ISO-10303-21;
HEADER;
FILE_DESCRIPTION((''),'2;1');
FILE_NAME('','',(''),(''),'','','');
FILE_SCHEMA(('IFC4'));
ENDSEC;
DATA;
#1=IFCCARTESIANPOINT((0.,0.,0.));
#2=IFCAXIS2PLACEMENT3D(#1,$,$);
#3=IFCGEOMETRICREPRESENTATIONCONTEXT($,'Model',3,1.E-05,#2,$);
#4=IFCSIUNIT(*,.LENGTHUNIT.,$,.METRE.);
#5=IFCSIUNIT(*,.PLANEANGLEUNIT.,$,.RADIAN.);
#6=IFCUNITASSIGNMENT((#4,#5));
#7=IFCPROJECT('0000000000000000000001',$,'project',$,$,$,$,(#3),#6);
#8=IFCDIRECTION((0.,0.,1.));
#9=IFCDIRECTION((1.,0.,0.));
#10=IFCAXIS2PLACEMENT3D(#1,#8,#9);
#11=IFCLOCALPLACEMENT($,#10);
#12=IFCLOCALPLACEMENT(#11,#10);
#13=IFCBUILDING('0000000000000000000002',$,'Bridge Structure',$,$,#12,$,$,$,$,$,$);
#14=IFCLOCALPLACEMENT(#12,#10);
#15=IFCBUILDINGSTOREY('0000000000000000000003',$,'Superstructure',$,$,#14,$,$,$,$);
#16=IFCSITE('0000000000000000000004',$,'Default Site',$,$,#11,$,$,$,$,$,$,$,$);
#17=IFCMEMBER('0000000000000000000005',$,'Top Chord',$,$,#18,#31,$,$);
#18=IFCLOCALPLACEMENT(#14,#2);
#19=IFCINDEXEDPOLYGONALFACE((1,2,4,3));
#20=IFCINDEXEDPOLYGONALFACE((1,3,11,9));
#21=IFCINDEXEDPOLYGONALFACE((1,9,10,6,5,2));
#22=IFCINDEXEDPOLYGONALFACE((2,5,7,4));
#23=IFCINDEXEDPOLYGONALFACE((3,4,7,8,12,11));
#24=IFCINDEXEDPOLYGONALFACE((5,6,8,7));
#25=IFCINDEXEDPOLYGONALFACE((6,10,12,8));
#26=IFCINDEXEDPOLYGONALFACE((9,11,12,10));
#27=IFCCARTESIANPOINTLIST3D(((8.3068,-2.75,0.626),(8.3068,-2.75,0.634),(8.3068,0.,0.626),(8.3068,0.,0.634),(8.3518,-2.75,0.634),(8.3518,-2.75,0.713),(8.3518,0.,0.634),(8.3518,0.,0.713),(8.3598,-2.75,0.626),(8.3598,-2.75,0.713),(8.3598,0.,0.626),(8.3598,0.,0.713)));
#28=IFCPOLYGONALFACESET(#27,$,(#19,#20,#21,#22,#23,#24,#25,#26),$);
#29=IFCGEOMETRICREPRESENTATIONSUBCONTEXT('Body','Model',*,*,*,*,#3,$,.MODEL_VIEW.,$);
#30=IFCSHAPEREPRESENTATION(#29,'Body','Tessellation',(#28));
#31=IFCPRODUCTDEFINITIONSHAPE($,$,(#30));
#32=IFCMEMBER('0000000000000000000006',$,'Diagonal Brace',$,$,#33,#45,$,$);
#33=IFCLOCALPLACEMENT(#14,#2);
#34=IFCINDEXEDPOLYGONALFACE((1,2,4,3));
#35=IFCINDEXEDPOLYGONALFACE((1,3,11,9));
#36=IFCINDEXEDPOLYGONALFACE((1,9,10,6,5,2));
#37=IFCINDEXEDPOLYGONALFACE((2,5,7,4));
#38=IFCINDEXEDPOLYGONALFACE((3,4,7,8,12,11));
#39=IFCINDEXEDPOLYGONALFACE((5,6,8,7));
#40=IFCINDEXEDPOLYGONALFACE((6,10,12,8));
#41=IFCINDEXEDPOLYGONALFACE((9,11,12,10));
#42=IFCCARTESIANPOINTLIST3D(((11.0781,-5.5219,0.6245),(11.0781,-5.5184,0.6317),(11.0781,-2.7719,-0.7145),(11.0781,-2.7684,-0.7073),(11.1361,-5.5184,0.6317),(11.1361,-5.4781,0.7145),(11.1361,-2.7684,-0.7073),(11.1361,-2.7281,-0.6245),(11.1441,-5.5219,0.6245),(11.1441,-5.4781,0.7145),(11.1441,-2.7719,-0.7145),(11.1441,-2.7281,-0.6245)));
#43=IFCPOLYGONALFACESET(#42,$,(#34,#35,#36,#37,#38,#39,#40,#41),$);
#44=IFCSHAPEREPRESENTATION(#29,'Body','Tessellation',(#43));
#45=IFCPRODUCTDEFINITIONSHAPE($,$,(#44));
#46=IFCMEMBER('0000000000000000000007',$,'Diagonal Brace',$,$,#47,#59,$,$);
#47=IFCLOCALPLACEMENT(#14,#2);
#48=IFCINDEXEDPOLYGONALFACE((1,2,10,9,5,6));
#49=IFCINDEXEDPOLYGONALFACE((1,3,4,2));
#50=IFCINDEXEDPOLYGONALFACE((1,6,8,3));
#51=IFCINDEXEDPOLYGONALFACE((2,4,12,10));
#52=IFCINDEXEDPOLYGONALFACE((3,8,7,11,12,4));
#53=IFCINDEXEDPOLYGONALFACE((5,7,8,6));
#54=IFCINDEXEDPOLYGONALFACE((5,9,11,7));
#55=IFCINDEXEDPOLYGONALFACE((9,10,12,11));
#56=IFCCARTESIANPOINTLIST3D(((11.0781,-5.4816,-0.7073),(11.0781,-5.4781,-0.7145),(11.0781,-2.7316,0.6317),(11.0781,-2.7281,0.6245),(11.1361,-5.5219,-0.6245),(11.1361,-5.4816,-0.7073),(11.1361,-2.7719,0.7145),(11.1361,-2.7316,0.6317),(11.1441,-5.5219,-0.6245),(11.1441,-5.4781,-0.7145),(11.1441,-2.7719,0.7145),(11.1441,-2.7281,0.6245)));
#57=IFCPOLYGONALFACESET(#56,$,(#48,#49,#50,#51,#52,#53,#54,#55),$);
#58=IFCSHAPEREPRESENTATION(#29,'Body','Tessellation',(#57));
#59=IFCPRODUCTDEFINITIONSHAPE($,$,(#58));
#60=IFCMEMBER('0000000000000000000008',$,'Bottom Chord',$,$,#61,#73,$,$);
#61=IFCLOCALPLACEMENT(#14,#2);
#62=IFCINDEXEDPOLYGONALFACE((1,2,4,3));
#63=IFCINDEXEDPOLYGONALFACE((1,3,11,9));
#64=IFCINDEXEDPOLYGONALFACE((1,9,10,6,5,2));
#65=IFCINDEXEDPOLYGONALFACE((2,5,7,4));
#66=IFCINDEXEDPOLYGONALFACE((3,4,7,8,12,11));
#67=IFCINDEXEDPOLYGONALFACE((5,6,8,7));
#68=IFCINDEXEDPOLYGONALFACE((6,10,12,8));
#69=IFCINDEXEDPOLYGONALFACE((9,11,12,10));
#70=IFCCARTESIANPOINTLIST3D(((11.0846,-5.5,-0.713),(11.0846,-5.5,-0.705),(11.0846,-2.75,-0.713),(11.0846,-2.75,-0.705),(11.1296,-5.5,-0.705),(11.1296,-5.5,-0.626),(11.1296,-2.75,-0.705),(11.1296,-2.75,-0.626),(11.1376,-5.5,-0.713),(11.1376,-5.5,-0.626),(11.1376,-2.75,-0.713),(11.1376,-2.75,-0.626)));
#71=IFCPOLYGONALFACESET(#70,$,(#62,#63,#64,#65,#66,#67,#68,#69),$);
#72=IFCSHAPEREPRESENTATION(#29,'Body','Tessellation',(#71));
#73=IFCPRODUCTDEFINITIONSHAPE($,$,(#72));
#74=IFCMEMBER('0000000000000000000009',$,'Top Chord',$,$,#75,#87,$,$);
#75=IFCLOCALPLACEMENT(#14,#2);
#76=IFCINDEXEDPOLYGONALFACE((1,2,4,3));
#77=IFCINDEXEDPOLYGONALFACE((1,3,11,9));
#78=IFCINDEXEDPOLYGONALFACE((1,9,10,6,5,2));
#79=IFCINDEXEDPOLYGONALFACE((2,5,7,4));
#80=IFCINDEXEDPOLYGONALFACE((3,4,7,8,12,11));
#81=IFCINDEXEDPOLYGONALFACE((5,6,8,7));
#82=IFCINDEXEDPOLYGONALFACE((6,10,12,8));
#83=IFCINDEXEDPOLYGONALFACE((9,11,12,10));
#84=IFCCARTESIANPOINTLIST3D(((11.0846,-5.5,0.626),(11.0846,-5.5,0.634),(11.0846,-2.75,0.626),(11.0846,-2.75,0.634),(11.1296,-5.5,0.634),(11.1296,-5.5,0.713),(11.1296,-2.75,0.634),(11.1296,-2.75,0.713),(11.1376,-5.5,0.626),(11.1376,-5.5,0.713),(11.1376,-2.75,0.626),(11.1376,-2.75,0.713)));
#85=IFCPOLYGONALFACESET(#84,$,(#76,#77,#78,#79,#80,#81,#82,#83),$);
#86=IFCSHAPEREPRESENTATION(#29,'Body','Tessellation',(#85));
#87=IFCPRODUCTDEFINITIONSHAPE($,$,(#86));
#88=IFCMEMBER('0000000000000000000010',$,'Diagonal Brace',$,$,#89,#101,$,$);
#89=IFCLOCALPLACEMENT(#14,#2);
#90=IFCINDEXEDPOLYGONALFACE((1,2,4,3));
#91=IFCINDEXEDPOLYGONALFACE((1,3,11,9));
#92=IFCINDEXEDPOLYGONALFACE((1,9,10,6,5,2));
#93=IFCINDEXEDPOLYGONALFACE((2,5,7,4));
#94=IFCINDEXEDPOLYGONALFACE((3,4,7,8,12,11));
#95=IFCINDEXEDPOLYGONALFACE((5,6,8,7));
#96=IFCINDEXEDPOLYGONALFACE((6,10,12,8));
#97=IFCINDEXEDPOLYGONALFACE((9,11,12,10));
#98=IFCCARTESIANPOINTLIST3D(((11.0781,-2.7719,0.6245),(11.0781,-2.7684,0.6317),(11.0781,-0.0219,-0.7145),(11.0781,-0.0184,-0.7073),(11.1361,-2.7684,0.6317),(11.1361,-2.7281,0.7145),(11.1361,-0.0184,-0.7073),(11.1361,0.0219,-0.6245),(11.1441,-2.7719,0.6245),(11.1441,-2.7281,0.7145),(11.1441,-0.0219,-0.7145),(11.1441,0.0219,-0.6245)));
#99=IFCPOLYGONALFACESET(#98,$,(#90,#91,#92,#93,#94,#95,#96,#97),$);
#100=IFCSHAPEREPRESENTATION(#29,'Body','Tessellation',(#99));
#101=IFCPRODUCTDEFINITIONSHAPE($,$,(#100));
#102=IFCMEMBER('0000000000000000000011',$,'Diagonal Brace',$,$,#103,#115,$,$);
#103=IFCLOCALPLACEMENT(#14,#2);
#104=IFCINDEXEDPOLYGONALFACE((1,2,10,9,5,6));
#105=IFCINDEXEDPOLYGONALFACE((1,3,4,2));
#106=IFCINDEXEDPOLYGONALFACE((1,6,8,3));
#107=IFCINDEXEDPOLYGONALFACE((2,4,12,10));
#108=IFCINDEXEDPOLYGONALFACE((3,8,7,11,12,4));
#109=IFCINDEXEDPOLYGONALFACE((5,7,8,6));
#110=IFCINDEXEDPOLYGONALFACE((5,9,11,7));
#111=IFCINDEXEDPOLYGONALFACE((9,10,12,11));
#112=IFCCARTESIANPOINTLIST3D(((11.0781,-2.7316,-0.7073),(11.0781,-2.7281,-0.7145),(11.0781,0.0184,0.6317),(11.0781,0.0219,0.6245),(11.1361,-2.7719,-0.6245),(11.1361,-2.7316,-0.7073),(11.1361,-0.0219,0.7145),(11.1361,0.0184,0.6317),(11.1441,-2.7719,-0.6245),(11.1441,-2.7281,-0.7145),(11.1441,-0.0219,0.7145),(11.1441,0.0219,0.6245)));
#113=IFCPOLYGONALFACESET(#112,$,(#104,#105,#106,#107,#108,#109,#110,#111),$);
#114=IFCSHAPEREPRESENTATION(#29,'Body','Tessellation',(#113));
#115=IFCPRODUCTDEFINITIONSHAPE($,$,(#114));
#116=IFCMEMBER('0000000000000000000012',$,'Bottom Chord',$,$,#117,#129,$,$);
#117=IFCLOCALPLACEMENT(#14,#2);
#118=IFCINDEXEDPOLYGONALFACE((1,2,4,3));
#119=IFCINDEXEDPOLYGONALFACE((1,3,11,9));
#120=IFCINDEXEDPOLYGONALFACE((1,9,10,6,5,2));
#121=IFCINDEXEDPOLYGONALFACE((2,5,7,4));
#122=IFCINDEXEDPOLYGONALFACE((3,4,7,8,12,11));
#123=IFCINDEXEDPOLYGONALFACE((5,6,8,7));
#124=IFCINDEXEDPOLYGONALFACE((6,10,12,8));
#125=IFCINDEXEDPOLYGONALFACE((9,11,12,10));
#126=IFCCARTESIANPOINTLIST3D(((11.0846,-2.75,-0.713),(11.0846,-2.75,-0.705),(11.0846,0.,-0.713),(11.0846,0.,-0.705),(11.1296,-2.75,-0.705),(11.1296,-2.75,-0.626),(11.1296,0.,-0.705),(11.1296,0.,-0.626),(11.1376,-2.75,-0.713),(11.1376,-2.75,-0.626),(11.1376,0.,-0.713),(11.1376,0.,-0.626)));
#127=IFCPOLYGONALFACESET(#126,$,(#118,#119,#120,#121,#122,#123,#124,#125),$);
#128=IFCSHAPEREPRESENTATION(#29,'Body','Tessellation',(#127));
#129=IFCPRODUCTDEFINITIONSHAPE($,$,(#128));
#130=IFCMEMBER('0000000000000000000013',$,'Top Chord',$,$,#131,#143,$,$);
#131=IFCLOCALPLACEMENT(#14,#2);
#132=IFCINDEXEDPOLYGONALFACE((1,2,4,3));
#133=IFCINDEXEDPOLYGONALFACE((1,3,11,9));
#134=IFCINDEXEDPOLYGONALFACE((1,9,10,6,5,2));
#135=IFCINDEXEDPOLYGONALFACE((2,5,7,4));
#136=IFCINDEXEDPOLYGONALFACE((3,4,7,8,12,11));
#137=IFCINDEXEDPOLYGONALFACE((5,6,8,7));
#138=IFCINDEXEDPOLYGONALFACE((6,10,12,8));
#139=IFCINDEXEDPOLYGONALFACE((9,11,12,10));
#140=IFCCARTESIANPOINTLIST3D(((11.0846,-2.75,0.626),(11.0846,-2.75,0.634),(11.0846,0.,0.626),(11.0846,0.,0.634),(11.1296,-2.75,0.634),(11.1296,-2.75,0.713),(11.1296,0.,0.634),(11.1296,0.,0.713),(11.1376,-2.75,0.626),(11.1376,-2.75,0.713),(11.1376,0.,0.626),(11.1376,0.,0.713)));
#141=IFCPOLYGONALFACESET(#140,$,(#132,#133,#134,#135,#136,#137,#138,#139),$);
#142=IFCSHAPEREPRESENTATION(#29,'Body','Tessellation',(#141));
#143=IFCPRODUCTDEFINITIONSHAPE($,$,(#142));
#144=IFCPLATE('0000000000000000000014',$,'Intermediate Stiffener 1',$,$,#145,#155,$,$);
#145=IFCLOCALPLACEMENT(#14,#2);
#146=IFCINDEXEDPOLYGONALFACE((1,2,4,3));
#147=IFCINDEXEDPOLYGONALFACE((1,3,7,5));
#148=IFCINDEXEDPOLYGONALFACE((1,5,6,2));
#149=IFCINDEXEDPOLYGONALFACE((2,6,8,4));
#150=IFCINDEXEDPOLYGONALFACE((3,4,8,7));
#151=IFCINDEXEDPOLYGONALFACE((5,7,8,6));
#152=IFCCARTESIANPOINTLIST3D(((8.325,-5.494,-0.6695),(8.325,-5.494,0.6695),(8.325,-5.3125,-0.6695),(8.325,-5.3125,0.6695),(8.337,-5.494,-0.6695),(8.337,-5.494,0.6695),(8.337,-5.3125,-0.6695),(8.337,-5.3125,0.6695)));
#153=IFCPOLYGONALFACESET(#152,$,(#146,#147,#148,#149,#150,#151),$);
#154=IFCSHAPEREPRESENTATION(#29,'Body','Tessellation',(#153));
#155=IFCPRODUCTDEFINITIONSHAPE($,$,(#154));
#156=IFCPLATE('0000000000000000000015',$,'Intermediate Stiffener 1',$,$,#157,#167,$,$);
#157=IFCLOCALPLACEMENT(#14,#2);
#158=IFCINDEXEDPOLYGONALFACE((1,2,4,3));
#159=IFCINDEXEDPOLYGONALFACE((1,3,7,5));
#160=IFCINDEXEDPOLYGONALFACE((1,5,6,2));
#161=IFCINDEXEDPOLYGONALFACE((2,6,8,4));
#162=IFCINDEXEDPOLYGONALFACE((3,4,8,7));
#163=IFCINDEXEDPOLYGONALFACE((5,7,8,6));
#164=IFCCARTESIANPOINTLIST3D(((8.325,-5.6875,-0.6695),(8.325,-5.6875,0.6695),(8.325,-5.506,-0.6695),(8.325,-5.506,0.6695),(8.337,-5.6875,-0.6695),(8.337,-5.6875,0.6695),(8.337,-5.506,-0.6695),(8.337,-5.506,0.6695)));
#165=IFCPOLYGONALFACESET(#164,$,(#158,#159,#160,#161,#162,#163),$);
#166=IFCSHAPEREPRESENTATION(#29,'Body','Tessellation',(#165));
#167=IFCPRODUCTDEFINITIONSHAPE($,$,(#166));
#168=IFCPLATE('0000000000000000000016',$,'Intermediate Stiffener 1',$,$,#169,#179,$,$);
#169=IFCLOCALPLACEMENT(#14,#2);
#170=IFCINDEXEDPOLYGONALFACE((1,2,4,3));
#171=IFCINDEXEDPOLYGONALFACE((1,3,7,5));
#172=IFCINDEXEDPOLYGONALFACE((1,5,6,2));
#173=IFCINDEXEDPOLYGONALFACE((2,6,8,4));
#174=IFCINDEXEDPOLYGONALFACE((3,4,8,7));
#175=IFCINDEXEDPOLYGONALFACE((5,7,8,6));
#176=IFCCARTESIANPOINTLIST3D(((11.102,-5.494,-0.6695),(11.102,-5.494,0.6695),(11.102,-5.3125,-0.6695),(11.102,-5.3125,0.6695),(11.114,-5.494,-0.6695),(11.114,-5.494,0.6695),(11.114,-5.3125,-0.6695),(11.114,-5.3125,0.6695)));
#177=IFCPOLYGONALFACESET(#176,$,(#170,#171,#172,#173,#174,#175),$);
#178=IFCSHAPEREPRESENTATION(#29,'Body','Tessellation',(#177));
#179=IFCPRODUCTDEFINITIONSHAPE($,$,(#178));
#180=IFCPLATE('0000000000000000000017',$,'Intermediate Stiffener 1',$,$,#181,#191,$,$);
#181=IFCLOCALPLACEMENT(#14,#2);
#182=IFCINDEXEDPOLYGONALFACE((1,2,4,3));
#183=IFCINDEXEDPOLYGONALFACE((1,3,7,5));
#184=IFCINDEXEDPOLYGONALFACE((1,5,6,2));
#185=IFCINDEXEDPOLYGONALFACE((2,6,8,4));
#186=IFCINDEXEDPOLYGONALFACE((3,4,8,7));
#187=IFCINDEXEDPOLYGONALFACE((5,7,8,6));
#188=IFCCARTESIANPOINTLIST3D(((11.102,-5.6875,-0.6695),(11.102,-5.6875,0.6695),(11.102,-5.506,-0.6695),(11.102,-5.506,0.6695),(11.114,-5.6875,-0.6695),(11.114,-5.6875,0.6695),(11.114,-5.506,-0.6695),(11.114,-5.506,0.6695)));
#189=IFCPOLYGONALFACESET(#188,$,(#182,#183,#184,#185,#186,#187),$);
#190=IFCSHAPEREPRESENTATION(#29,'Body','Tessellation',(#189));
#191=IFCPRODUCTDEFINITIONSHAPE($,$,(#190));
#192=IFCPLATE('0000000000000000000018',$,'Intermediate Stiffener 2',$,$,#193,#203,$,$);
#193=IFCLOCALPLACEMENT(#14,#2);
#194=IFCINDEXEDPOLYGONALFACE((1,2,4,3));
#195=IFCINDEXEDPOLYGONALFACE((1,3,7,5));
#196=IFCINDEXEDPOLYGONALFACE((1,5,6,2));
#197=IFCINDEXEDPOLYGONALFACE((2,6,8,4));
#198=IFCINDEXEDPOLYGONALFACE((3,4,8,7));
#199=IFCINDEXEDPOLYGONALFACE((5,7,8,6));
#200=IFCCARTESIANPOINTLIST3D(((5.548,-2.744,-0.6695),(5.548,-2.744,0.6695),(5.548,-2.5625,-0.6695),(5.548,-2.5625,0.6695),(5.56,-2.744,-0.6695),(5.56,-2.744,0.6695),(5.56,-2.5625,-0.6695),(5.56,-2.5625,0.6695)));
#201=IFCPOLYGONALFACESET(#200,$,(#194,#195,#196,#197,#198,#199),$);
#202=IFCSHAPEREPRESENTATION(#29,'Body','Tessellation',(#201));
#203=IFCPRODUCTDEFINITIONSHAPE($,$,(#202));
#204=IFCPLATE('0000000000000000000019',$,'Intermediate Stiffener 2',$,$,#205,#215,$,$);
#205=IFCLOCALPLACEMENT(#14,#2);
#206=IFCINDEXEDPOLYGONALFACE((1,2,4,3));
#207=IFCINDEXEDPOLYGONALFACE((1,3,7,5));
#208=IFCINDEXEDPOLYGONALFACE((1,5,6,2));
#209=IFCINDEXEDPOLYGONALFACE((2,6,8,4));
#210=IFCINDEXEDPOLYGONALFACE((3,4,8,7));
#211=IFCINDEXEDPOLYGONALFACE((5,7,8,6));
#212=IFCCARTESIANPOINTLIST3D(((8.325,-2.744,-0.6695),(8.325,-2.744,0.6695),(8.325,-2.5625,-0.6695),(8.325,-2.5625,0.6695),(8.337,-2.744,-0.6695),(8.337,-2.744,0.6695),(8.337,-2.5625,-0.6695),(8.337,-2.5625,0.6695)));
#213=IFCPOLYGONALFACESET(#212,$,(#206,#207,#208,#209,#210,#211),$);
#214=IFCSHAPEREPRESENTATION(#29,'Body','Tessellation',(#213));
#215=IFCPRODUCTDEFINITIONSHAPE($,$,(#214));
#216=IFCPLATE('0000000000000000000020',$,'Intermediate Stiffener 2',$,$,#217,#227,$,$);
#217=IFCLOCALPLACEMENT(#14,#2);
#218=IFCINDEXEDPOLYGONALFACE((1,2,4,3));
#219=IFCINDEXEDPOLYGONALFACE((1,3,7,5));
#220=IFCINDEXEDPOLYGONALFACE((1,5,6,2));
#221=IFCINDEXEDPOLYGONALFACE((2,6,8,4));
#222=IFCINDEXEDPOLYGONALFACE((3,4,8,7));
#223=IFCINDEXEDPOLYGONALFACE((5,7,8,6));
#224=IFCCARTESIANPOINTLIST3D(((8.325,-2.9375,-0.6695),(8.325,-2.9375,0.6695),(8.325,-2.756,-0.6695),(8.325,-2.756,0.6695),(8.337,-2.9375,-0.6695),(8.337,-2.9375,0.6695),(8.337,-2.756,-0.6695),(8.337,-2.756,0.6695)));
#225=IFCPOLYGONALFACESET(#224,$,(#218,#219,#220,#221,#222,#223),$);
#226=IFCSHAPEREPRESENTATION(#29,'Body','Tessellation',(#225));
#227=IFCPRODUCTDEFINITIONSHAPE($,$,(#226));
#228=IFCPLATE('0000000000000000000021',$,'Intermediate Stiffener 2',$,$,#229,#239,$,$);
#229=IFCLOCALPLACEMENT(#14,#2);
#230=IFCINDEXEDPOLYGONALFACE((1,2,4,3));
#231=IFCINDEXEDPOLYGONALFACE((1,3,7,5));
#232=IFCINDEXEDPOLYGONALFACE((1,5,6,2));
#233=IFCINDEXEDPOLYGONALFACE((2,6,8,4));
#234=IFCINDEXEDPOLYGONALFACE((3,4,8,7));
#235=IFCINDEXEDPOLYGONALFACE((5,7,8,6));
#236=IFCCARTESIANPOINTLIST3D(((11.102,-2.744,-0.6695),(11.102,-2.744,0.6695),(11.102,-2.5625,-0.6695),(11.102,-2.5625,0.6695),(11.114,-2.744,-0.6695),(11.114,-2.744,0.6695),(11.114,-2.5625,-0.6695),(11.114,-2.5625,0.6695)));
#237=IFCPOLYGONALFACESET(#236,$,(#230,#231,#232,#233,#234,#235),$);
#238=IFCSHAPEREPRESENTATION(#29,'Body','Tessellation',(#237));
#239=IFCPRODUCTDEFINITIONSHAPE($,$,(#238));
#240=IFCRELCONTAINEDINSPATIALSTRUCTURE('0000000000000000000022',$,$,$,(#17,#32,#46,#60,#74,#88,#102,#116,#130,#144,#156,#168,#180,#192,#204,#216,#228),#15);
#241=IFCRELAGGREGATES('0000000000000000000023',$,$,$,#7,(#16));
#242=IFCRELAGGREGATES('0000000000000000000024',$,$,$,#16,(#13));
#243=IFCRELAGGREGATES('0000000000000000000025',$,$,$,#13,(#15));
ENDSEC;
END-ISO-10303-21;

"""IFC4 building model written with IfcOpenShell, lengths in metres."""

from ifc_helpers import new_model, si_unit, frame, origin, origin_with_axes, origin_2d_with_axis, place, context, subcontext, project, spatial, rectangle, l_section, extrude, element, save


model = new_model("IFC4")

# Units and contexts
model_context = context("Model", 3, precision=1e-05, world=origin())
body_context = subcontext(model_context, "Body", "Model", "MODEL_VIEW")
ifc_project = project(units=[si_unit("LENGTHUNIT", "METRE"), si_unit("PLANEANGLEUNIT", "RADIAN")], contexts=[model_context])

# Site, building, storey
site_placement = place(None, origin_with_axes())
site = spatial("IfcSite", under=ifc_project, at=site_placement, Name="Default Site")
building_placement = place(site_placement, origin_with_axes())
building = spatial("IfcBuilding", under=site, at=building_placement, Name="Bridge Structure")
storey_placement = place(building_placement, origin_with_axes())
storey = spatial("IfcBuildingStorey", under=building, at=storey_placement, Name="Superstructure")

# Members
for number, where, z_axis, x_axis, name in (
    (1, (8.3333, -2.75, 0.6695), (0.0, 1.0, 0.0), (-1.0, 0.0, 0.0), "Top Chord"),
):
    element("IfcMember", number, at=place(storey_placement, frame(where, z_axis=z_axis, x_axis=x_axis)), inside=storey, Name=name, context=body_context, shape_type="SweptSolid", body=[
        extrude(l_section(Depth=0.087, Width=0.053, Thickness=0.008, at=origin_2d_with_axis()), origin_with_axes(), (0.0, 0.0, 1.0), 2.75),
    ])
for number, where, z_axis, x_axis, name in (
    (2, (11.1111, -5.5, 0.6695), (0.0, 0.899086, -0.437773), (-1.0, 0.0, 0.0), "Diagonal Brace"),
    (3, (11.1111, -5.5, -0.6695), (0.0, 0.899086, 0.437773), (-1.0, 0.0, 0.0), "Diagonal Brace"),
):
    element("IfcMember", number, at=place(storey_placement, frame(where, z_axis=z_axis, x_axis=x_axis)), inside=storey, Name=name, context=body_context, shape_type="SweptSolid", body=[
        extrude(l_section(Depth=0.1, Width=0.066, Thickness=0.008, at=origin_2d_with_axis()), origin_with_axes(), (0.0, 0.0, 1.0), 3.0587),
    ])
for number, where, z_axis, x_axis, name in (
    (4, (11.1111, -5.5, -0.6695), (0.0, 1.0, 0.0), (-1.0, 0.0, 0.0), "Bottom Chord"),
    (5, (11.1111, -5.5, 0.6695), (0.0, 1.0, 0.0), (-1.0, 0.0, 0.0), "Top Chord"),
):
    element("IfcMember", number, at=place(storey_placement, frame(where, z_axis=z_axis, x_axis=x_axis)), inside=storey, Name=name, context=body_context, shape_type="SweptSolid", body=[
        extrude(l_section(Depth=0.087, Width=0.053, Thickness=0.008, at=origin_2d_with_axis()), origin_with_axes(), (0.0, 0.0, 1.0), 2.75),
    ])
for number, where, z_axis, x_axis, name in (
    (6, (11.1111, -2.75, 0.6695), (0.0, 0.899086, -0.437773), (-1.0, 0.0, 0.0), "Diagonal Brace"),
    (7, (11.1111, -2.75, -0.6695), (0.0, 0.899086, 0.437773), (-1.0, 0.0, 0.0), "Diagonal Brace"),
):
    element("IfcMember", number, at=place(storey_placement, frame(where, z_axis=z_axis, x_axis=x_axis)), inside=storey, Name=name, context=body_context, shape_type="SweptSolid", body=[
        extrude(l_section(Depth=0.1, Width=0.066, Thickness=0.008, at=origin_2d_with_axis()), origin_with_axes(), (0.0, 0.0, 1.0), 3.0587),
    ])
for number, where, z_axis, x_axis, name in (
    (8, (11.1111, -2.75, -0.6695), (0.0, 1.0, 0.0), (-1.0, 0.0, 0.0), "Bottom Chord"),
    (9, (11.1111, -2.75, 0.6695), (0.0, 1.0, 0.0), (-1.0, 0.0, 0.0), "Top Chord"),
):
    element("IfcMember", number, at=place(storey_placement, frame(where, z_axis=z_axis, x_axis=x_axis)), inside=storey, Name=name, context=body_context, shape_type="SweptSolid", body=[
        extrude(l_section(Depth=0.087, Width=0.053, Thickness=0.008, at=origin_2d_with_axis()), origin_with_axes(), (0.0, 0.0, 1.0), 2.75),
    ])

# Plates
for number, where, z_axis, x_axis, name in (
    (10, (8.331, -5.4032, -0.6695), (0.0, 0.0, 1.0), (1.0, 0.0, 0.0), "Intermediate Stiffener 1"),
    (11, (8.331, -5.5968, -0.6695), (0.0, 0.0, 1.0), (1.0, 0.0, 0.0), "Intermediate Stiffener 1"),
    (12, (11.108, -5.4032, -0.6695), (0.0, 0.0, 1.0), (1.0, 0.0, 0.0), "Intermediate Stiffener 1"),
    (13, (11.108, -5.5968, -0.6695), (0.0, 0.0, 1.0), (1.0, 0.0, 0.0), "Intermediate Stiffener 1"),
    (14, (5.554, -2.6532, -0.6695), (0.0, 0.0, 1.0), (1.0, 0.0, 0.0), "Intermediate Stiffener 2"),
    (15, (8.331, -2.6532, -0.6695), (0.0, 0.0, 1.0), (1.0, 0.0, 0.0), "Intermediate Stiffener 2"),
    (16, (8.331, -2.8468, -0.6695), (0.0, 0.0, 1.0), (1.0, 0.0, 0.0), "Intermediate Stiffener 2"),
    (17, (11.108, -2.6532, -0.6695), (0.0, 0.0, 1.0), (1.0, 0.0, 0.0), "Intermediate Stiffener 2"),
):
    element("IfcPlate", number, at=place(storey_placement, frame(where, z_axis=z_axis, x_axis=x_axis)), inside=storey, Name=name, context=body_context, shape_type="SweptSolid", body=[
        extrude(rectangle(XDim=0.012, YDim=0.1815, at=origin_2d_with_axis()), origin_with_axes(), (0.0, 0.0, 1.0), 1.339),
    ])

save(model, "model.ifc")
